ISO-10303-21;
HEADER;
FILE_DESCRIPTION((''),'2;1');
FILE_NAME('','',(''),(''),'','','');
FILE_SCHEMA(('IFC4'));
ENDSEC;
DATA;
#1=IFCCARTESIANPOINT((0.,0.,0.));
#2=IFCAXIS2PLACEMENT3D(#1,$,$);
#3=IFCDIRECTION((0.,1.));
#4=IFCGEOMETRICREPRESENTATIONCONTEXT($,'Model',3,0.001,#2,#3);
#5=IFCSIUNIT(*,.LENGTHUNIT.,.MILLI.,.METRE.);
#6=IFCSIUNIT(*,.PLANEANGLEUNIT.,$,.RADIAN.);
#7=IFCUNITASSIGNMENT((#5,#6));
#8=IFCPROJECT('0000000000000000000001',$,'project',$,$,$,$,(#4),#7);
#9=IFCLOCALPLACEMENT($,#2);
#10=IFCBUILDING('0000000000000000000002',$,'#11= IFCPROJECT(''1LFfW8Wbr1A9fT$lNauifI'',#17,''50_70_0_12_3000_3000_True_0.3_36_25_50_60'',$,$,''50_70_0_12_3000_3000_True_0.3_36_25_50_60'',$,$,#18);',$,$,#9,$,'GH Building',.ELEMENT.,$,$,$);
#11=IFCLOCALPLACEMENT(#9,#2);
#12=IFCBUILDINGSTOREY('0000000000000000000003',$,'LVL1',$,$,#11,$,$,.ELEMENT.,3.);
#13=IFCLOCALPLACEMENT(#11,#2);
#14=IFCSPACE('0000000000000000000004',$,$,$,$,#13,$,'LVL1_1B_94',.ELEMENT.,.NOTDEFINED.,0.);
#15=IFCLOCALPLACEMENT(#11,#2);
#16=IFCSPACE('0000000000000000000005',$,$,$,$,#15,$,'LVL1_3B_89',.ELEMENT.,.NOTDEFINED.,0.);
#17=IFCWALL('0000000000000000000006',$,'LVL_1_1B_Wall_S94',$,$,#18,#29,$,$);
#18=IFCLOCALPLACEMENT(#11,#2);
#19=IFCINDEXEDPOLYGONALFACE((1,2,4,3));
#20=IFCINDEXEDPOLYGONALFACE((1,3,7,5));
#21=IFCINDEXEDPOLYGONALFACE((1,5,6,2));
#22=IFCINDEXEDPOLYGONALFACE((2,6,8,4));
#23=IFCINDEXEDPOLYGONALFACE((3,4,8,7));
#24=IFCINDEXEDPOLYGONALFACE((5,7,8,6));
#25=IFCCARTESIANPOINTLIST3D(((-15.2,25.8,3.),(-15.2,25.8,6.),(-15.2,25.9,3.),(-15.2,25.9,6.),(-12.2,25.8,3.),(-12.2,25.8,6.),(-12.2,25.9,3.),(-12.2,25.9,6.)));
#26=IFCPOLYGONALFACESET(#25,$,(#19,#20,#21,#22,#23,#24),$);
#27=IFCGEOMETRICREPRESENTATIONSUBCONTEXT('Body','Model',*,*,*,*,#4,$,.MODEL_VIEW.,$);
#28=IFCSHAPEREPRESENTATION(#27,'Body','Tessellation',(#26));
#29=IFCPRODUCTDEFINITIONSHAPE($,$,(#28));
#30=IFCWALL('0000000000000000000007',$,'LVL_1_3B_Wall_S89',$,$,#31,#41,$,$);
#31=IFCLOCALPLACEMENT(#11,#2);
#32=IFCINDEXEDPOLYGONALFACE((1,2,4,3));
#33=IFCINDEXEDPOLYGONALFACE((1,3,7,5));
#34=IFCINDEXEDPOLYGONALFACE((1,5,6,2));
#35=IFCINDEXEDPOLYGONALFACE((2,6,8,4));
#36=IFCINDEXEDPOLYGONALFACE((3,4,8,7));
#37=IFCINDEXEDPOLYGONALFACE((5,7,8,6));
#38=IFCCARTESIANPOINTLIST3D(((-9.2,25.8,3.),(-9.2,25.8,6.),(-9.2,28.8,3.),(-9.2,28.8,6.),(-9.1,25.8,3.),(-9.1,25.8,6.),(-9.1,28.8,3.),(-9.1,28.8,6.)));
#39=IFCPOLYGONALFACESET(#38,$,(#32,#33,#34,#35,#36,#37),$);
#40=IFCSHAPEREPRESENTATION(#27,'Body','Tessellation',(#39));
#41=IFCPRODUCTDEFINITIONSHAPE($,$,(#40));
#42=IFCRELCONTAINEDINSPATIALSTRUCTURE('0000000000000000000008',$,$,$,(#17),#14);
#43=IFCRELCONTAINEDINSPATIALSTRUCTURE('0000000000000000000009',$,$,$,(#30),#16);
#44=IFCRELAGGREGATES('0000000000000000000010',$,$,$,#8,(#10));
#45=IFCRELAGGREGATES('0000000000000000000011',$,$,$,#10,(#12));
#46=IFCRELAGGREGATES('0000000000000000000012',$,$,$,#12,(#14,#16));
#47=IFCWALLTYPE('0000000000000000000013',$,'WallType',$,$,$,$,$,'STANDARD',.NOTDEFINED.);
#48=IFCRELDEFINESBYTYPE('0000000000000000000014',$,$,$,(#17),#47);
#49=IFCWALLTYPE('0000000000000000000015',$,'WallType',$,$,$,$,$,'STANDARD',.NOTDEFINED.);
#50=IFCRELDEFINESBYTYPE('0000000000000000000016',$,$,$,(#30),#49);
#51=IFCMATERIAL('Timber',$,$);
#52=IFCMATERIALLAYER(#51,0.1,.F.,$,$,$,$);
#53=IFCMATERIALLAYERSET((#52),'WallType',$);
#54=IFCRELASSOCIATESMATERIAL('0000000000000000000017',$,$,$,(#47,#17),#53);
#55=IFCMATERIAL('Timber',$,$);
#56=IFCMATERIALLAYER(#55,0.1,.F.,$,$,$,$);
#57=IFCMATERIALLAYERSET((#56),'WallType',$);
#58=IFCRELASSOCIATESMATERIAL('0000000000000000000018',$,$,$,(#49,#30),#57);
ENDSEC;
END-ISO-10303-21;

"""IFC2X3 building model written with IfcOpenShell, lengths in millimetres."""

from ifc_helpers import new_model, si_unit, direction, frame, frame_2d, origin, place, context, subcontext, project, spatial, rectangle, extrude, material, layer, layer_set, layer_usage, type_object, element, save


model = new_model("IFC2X3")

# Units and contexts
model_context = context("Model", 3, precision=0.001, world=origin(), true_north=direction((0.0, 1.0)))
body_context = subcontext(model_context, "Body", "Model", "MODEL_VIEW")
ifc_project = project(units=[si_unit("LENGTHUNIT", "METRE", prefix="MILLI"), si_unit("PLANEANGLEUNIT", "RADIAN")], contexts=[model_context])

# Building, storey
building_placement = place(None, origin())
building = spatial("IfcBuilding", under=ifc_project, at=building_placement, Name="#11= IFCPROJECT('1LFfW8Wbr1A9fT$lNauifI',#17,'50_70_0_12_3000_3000_True_0.3_36_25_50_60',$,$,'50_70_0_12_3000_3000_True_0.3_36_25_50_60',$,$,#18);", LongName="GH Building", CompositionType="ELEMENT")
storey_placement = place(building_placement, origin())
storey = spatial("IfcBuildingStorey", under=building, at=storey_placement, Name="LVL1", CompositionType="ELEMENT", Elevation=3.0)

# Shared definitions
space_1_placement = place(storey_placement, origin())
space_1 = spatial("IfcSpace", under=storey, at=space_1_placement, LongName="LVL1_1B_94", CompositionType="ELEMENT", InteriorOrExteriorSpace="NOTDEFINED", ElevationWithFlooring=0.0)

# Wall
ifc_material_1 = material(Name="Timber")
ifc_layer_1 = layer(ifc_material_1, 0.1, ventilated=False)
ifc_layer_set_1 = layer_set([ifc_layer_1], Name="WallType")
ifc_layer_usage_1 = layer_usage(ifc_layer_set_1, "AXIS2", "NEGATIVE", 0.0)
wall_type_1 = type_object("IfcWallType", Name="WallType", ElementType="STANDARD", PredefinedType="NOTDEFINED", material=ifc_layer_set_1)
wall_1_placement = place(space_1_placement, frame((-12.2, 25.8, 3.0), z_axis=(0.0, 0.0, 1.0), x_axis=(-1.0, 0.0, 0.0)))
element("IfcWall", 1, at=wall_1_placement, inside=space_1, type_object=wall_type_1, material=ifc_layer_usage_1, Name="LVL_1_1B_Wall_S94", context=body_context, shape_type="SweptSolid", body=[
    extrude(rectangle(XDim=3.0, YDim=0.1, at=frame_2d((1.5, -0.1))), origin(), (0.0, 0.0, 1.0), 3.0),
])

# Shared definitions
space_2_placement = place(storey_placement, origin())
space_2 = spatial("IfcSpace", under=storey, at=space_2_placement, LongName="LVL1_3B_89", CompositionType="ELEMENT", InteriorOrExteriorSpace="NOTDEFINED", ElevationWithFlooring=0.0)

# Wall
ifc_material_2 = material(Name="Timber")
ifc_layer_2 = layer(ifc_material_2, 0.1, ventilated=False)
ifc_layer_set_2 = layer_set([ifc_layer_2], Name="WallType")
ifc_layer_usage_2 = layer_usage(ifc_layer_set_2, "AXIS2", "NEGATIVE", 0.0)
wall_type_2 = type_object("IfcWallType", Name="WallType", ElementType="STANDARD", PredefinedType="NOTDEFINED", material=ifc_layer_set_2)
wall_2_placement = place(space_2_placement, frame((-9.2, 25.8, 3.0), z_axis=(0.0, 0.0, 1.0), x_axis=(0.0, 1.0, 0.0)))
element("IfcWall", 2, at=wall_2_placement, inside=space_2, type_object=wall_type_2, material=ifc_layer_usage_2, Name="LVL_1_3B_Wall_S89", context=body_context, shape_type="SweptSolid", body=[
    extrude(rectangle(XDim=3.0, YDim=0.1, at=frame_2d((1.5, -0.1))), origin(), (0.0, 0.0, 1.0), 3.0),
])

save(model, "model.ifc")
